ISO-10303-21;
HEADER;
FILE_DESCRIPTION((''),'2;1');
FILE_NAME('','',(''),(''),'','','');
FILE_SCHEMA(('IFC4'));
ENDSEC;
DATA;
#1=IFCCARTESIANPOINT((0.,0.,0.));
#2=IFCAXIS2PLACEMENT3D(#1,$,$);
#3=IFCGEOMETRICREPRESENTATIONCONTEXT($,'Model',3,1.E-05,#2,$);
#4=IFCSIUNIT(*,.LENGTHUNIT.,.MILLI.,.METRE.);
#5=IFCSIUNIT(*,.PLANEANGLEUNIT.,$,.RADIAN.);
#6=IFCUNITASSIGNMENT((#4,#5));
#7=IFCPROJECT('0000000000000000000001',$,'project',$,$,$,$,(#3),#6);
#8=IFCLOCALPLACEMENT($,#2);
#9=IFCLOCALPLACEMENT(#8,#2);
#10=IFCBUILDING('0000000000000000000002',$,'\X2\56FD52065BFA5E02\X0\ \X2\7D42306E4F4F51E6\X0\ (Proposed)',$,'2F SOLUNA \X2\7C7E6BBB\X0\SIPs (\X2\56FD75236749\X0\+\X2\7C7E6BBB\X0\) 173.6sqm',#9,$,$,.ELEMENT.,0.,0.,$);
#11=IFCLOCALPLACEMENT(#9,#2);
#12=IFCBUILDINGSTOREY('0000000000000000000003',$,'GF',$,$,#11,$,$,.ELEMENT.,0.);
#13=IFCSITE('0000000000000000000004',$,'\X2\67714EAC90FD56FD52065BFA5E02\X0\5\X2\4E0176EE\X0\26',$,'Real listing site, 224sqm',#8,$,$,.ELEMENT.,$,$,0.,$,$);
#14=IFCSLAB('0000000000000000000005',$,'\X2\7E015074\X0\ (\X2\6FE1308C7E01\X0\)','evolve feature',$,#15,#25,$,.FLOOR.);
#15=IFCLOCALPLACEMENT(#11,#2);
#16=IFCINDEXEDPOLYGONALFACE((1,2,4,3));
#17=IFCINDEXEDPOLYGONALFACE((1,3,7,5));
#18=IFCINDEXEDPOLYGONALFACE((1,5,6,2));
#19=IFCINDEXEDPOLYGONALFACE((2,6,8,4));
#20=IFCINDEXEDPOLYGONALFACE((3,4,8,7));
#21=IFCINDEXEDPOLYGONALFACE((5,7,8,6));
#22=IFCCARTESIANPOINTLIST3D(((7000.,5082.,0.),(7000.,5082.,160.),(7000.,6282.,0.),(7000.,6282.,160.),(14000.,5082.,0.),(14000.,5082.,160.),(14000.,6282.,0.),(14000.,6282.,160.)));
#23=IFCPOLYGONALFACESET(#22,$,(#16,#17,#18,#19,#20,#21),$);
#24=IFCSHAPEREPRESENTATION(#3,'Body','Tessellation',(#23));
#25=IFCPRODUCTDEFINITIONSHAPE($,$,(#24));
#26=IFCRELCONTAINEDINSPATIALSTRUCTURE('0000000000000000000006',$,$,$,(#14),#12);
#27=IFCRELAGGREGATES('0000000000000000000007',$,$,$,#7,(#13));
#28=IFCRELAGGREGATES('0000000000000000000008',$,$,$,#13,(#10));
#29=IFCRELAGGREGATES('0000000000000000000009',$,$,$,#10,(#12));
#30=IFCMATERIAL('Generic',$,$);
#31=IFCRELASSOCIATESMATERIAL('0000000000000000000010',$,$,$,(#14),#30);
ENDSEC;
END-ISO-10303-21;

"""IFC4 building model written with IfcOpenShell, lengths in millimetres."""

from ifc_helpers import new_model, si_unit, frame, frame_2d, origin, place, context, project, spatial, rectangle, extrude, material, element, save


model = new_model("IFC4")

# Units and contexts
model_context = context("Model", 3, precision=1e-05, world=origin())
ifc_project = project(units=[si_unit("LENGTHUNIT", "METRE", prefix="MILLI"), si_unit("PLANEANGLEUNIT", "RADIAN")], contexts=[model_context])

# Site, building, storey
site_placement = place(None, origin())
site = spatial("IfcSite", under=ifc_project, at=site_placement, Name="東京都国分寺市5丁目26", ObjectType="Real listing site, 224sqm", CompositionType="ELEMENT", RefElevation=0.0)
building_placement = place(site_placement, origin())
building = spatial("IfcBuilding", under=site, at=building_placement, Name="国分寺市 終の住処 (Proposed)", ObjectType="2F SOLUNA 籾殻SIPs (国産杉+籾殻) 173.6sqm", CompositionType="ELEMENT", ElevationOfRefHeight=0.0, ElevationOfTerrain=0.0)
storey_placement = place(building_placement, origin())
storey = spatial("IfcBuildingStorey", under=building, at=storey_placement, Name="GF", CompositionType="ELEMENT", Elevation=0.0)

# Slab
ifc_material_1 = material(Name="Generic")
slab_1_placement = place(storey_placement, frame((3500.0, 2541.0, 0.0)))
element("IfcSlab", 1, at=slab_1_placement, inside=storey, material=ifc_material_1, Name="縁側 (濡れ縁)", Description="evolve feature", PredefinedType="FLOOR", context=model_context, shape_type="SweptSolid", body=[
    extrude(rectangle(XDim=7000.0, YDim=1200.0, at=frame_2d((3500.0, 600.0))), frame((3500.0, 2541.0, 0.0)), (0.0, 0.0, 1.0), 160.0),
])

save(model, "model.ifc")
